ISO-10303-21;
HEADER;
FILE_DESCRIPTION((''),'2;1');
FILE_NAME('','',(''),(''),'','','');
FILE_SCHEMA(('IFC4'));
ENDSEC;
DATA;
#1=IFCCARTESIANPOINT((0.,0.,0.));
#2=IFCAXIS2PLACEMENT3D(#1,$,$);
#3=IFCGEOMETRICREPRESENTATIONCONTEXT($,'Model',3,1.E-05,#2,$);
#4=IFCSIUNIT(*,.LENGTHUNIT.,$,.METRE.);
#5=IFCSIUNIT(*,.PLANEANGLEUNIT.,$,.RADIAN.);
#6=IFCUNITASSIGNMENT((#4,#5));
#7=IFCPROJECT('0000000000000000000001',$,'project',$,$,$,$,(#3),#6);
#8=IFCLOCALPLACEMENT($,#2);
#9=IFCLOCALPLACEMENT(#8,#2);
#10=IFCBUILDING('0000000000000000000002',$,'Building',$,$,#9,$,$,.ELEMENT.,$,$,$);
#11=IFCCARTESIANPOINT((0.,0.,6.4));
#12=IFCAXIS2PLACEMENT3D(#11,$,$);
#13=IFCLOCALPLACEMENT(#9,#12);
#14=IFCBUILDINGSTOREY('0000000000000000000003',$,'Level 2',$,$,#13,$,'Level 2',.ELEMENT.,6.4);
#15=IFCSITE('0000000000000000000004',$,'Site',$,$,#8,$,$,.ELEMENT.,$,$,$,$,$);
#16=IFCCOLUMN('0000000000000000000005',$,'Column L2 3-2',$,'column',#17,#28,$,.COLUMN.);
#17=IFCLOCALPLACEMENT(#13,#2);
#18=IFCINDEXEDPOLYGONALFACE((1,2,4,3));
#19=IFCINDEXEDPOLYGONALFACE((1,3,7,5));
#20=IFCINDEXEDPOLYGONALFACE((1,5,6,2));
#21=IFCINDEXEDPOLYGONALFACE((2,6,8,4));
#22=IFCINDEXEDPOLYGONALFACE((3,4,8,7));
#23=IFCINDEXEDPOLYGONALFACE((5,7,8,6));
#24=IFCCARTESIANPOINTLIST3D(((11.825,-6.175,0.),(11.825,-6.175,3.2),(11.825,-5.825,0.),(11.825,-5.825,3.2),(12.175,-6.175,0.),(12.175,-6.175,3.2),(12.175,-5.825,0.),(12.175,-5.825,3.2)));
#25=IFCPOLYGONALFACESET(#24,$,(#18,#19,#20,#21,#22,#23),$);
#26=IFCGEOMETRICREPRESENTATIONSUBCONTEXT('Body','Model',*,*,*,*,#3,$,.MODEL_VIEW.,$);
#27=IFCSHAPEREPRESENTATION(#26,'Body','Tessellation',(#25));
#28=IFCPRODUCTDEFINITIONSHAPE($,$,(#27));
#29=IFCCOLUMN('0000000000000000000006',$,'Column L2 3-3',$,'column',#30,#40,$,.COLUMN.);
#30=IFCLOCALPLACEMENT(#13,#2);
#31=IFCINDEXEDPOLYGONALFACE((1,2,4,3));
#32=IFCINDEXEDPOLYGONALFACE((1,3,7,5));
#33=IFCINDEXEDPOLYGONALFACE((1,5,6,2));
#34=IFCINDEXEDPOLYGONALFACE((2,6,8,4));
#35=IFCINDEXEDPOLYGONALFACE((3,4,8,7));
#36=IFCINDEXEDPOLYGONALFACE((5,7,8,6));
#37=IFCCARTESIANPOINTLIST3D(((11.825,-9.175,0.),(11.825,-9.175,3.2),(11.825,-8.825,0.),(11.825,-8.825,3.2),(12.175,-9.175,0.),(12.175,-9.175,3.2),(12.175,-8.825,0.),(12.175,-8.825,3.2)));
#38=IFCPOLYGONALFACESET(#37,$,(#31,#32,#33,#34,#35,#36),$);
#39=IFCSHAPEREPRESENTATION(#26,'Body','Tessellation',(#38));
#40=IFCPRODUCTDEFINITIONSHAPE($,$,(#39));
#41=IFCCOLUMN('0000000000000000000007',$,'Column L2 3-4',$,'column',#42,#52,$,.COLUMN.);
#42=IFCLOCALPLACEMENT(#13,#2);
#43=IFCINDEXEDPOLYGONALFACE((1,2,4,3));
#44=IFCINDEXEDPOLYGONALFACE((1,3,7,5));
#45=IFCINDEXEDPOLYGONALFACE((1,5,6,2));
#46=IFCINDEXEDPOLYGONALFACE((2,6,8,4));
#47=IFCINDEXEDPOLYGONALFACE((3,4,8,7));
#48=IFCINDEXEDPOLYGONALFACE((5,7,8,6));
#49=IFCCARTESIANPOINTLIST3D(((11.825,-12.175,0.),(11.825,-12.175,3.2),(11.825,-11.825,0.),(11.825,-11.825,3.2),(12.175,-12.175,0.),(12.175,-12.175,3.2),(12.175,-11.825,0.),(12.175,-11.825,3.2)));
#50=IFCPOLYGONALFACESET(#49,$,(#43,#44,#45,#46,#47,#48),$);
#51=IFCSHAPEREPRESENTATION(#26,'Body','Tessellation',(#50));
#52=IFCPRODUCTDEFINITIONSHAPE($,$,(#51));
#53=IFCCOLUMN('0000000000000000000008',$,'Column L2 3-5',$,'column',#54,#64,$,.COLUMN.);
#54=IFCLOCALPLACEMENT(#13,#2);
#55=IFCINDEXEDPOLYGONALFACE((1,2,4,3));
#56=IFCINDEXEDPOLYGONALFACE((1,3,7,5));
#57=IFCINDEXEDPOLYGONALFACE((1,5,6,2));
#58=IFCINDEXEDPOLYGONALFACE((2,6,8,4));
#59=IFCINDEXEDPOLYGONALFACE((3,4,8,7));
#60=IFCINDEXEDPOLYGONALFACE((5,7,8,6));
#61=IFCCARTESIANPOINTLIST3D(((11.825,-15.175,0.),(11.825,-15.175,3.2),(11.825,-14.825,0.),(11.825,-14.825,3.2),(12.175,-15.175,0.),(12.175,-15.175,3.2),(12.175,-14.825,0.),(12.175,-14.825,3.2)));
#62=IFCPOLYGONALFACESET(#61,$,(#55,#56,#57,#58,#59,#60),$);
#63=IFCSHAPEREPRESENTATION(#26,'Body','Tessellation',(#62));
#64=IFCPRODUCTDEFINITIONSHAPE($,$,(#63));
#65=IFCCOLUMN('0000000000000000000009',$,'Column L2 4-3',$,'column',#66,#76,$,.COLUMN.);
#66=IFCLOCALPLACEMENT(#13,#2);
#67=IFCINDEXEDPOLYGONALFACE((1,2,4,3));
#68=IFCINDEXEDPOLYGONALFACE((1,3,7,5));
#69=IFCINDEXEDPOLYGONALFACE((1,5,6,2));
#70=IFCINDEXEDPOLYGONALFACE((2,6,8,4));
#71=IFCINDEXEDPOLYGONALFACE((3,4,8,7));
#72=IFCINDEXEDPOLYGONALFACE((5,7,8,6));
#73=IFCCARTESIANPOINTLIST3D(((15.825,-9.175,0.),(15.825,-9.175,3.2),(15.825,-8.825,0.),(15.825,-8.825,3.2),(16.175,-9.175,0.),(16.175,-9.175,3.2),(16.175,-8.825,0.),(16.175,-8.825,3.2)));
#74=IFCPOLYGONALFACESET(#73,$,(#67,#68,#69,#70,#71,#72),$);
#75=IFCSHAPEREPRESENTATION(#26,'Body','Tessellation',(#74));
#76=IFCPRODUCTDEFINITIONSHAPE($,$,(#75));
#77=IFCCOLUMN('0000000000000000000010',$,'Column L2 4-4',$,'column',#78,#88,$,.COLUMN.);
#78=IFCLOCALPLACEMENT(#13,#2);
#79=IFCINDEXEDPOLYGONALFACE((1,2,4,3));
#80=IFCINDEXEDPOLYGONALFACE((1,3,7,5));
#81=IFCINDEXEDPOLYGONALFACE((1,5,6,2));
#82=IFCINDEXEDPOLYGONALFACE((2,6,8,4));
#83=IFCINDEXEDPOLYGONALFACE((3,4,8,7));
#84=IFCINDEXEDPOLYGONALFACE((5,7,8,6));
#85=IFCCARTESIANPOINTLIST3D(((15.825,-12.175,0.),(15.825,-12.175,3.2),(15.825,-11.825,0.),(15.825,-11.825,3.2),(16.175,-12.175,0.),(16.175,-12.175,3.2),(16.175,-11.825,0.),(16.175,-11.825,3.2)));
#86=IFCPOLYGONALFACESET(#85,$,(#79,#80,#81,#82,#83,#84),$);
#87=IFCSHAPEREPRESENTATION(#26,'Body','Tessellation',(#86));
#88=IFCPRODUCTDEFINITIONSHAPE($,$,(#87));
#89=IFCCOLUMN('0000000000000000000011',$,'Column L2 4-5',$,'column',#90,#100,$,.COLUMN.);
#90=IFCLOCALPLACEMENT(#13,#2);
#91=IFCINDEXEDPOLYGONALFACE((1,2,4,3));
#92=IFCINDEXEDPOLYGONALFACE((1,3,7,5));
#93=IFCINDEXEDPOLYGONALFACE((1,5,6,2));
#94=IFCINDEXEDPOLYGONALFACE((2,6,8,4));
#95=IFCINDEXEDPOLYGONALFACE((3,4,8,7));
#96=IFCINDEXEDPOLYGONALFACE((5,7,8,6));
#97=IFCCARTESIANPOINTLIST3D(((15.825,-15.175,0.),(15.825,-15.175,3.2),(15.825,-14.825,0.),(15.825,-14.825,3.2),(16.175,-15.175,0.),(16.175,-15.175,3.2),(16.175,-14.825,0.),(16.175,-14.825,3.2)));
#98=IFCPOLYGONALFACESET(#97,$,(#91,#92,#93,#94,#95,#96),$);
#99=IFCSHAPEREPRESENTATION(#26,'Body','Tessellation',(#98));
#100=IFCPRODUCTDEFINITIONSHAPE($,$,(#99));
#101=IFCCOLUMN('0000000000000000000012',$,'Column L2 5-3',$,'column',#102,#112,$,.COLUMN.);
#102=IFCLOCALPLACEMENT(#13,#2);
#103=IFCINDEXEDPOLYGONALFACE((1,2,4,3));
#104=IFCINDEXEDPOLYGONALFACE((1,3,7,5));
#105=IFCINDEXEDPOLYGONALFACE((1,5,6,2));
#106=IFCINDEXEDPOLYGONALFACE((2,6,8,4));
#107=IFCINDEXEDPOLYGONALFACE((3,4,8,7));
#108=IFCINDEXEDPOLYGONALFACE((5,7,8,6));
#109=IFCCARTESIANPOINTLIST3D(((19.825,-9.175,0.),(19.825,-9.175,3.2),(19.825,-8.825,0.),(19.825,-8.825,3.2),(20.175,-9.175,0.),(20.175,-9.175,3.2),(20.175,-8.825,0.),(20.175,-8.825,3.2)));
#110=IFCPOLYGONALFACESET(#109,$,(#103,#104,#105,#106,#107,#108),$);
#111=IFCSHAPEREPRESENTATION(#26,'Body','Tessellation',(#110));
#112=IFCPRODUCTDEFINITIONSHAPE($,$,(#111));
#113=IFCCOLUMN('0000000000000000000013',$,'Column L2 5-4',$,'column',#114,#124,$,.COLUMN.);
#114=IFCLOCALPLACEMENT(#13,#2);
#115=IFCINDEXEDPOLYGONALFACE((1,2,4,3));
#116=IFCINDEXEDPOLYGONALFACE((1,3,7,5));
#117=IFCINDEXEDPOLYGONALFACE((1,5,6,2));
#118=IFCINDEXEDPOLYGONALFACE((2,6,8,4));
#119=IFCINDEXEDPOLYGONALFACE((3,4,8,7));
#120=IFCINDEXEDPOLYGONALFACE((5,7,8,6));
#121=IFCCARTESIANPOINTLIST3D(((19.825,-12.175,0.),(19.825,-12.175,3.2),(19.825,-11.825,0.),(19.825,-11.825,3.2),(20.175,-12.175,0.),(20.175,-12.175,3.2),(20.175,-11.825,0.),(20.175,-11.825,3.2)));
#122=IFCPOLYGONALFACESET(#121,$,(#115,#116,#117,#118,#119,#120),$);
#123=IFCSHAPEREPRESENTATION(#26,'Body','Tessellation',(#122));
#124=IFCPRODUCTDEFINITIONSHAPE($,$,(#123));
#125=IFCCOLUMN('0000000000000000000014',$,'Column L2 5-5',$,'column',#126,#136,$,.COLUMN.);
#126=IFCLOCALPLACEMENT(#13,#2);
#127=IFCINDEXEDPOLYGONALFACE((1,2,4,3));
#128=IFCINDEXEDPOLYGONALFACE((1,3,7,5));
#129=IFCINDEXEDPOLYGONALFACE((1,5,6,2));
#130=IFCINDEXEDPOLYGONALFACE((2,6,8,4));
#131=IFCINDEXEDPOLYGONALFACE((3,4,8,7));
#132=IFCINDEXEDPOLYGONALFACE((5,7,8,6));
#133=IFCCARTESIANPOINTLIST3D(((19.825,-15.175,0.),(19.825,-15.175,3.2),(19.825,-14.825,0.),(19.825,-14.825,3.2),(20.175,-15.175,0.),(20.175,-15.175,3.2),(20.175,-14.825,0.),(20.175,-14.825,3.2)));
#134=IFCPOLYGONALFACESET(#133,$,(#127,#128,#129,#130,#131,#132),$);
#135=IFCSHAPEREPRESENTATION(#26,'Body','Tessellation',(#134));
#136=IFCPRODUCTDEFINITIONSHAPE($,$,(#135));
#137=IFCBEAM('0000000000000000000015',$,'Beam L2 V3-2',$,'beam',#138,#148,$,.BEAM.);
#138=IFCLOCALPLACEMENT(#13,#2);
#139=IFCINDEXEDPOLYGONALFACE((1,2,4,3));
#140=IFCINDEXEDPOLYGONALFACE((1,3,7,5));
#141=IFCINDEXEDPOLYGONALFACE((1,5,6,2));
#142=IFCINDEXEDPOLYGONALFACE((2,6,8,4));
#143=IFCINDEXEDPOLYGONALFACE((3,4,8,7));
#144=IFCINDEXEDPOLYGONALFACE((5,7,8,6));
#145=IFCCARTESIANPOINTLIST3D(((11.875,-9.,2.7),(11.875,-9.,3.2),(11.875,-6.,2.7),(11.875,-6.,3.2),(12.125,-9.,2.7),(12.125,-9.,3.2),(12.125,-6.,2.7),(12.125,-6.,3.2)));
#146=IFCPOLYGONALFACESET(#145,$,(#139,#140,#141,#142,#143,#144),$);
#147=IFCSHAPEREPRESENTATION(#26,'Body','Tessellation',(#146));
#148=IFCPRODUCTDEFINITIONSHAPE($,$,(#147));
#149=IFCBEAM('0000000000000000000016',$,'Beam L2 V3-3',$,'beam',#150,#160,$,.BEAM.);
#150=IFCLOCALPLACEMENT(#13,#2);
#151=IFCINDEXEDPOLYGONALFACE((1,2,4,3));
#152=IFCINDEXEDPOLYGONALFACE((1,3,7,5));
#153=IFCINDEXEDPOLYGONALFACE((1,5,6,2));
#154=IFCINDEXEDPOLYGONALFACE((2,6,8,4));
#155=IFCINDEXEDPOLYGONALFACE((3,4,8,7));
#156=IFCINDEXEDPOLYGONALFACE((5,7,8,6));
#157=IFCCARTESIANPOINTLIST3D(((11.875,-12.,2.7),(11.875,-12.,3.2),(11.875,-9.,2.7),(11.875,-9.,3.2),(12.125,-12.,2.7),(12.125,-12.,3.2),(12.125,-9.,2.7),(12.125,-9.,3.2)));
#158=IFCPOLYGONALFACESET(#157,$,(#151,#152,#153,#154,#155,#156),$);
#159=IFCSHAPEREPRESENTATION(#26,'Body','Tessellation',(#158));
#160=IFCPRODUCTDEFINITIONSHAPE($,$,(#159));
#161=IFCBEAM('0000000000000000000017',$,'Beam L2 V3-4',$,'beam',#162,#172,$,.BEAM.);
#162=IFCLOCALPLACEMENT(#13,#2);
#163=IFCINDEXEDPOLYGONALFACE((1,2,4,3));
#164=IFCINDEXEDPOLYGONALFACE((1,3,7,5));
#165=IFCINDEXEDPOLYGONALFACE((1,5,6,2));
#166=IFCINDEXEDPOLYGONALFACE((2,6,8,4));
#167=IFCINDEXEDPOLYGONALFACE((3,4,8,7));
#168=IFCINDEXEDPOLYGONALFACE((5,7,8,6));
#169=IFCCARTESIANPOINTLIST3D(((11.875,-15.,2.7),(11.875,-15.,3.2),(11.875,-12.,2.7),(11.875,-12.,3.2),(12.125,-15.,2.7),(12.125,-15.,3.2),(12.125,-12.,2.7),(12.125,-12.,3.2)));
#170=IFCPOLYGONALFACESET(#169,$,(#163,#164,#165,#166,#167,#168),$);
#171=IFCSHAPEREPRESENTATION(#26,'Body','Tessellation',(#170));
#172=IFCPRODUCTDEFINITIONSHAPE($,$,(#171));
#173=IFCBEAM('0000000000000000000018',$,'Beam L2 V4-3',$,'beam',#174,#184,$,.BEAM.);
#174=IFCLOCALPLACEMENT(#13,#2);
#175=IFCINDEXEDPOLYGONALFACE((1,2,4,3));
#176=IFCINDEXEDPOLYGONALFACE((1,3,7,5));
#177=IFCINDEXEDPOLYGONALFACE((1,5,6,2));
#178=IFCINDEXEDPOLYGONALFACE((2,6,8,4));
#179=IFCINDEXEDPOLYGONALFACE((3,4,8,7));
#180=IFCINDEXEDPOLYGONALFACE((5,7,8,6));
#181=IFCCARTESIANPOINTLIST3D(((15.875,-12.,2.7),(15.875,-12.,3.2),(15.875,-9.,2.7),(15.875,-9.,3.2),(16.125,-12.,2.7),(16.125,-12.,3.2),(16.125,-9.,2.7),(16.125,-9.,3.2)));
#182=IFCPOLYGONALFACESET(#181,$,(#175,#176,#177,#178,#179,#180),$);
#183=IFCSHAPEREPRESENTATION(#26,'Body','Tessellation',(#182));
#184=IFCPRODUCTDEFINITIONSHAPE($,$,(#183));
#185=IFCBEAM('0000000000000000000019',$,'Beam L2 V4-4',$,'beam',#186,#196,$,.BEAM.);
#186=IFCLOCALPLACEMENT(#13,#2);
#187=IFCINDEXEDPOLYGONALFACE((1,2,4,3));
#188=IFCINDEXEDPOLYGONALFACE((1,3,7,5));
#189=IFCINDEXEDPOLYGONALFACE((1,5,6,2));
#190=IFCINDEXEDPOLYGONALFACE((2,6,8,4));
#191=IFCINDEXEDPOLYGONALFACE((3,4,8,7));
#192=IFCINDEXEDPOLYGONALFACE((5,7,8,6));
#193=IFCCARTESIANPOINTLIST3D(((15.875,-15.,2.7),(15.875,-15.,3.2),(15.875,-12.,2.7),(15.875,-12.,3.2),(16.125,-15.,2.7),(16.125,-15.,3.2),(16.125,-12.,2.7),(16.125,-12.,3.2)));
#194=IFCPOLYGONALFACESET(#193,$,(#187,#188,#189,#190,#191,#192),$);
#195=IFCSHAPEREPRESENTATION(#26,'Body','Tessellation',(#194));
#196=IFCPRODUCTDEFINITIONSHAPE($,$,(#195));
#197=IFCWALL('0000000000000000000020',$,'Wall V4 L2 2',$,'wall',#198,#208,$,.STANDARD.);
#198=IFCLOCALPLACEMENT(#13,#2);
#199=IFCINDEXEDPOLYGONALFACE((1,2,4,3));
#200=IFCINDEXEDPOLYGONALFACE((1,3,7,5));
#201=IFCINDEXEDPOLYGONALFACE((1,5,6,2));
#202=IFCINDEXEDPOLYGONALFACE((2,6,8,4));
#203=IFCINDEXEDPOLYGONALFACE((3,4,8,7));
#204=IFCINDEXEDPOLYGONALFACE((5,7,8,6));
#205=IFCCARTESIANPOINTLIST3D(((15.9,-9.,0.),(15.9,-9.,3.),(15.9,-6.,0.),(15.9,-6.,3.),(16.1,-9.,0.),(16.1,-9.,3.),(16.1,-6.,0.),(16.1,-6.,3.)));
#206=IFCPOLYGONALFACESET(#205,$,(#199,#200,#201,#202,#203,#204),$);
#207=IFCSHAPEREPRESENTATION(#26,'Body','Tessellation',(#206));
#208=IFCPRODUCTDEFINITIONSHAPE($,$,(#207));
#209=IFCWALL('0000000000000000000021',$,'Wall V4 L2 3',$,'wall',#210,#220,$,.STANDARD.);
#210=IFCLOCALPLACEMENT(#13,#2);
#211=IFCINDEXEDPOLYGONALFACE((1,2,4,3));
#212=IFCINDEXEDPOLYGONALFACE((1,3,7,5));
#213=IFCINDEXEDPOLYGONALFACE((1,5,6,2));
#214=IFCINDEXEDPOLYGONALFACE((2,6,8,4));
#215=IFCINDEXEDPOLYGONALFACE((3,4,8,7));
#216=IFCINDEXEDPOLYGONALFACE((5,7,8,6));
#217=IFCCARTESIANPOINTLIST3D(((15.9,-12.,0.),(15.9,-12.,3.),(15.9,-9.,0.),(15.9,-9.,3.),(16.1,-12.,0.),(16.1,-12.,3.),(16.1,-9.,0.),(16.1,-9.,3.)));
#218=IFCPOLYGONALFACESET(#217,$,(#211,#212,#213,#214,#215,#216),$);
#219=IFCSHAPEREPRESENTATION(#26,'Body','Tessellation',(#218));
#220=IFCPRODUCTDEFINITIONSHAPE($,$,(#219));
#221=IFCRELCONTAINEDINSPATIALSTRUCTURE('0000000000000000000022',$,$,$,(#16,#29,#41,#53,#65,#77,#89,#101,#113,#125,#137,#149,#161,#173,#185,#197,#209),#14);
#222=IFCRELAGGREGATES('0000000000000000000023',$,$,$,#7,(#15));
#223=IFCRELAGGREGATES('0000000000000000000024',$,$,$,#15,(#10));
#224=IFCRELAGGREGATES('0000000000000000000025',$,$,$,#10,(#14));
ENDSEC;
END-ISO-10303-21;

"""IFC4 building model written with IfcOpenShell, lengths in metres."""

from ifc_helpers import new_model, si_unit, frame, frame_2d, origin, origin_2d, place, context, subcontext, project, spatial, rectangle, extrude, element, save


model = new_model("IFC4")

# Units and contexts
model_context = context("Model", 3, precision=1e-05, world=origin())
body_context = subcontext(model_context, "Body", "Model", "MODEL_VIEW")
ifc_project = project(units=[si_unit("LENGTHUNIT", "METRE"), si_unit("PLANEANGLEUNIT", "RADIAN")], contexts=[model_context])

# Site, building, storey
site_placement = place(None, origin())
site = spatial("IfcSite", under=ifc_project, at=site_placement, Name="Site", CompositionType="ELEMENT")
building_placement = place(site_placement, origin())
building = spatial("IfcBuilding", under=site, at=building_placement, Name="Building", CompositionType="ELEMENT")
storey_placement = place(building_placement, frame((0.0, 0.0, 6.4)))
storey = spatial("IfcBuildingStorey", under=building, at=storey_placement, Name="Level 2", LongName="Level 2", CompositionType="ELEMENT", Elevation=6.4)

# Columns
for number, where, name in (
    (1, (12.0, -6.0, 0.0), "Column L2 3-2"),
    (2, (12.0, -9.0, 0.0), "Column L2 3-3"),
    (3, (12.0, -12.0, 0.0), "Column L2 3-4"),
    (4, (12.0, -15.0, 0.0), "Column L2 3-5"),
    (5, (16.0, -9.0, 0.0), "Column L2 4-3"),
    (6, (16.0, -12.0, 0.0), "Column L2 4-4"),
    (7, (16.0, -15.0, 0.0), "Column L2 4-5"),
    (8, (20.0, -9.0, 0.0), "Column L2 5-3"),
    (9, (20.0, -12.0, 0.0), "Column L2 5-4"),
    (10, (20.0, -15.0, 0.0), "Column L2 5-5"),
):
    element("IfcColumn", number, at=place(storey_placement, frame(where)), inside=storey, Name=name, ObjectType="column", PredefinedType="COLUMN", context=body_context, shape_type="SweptSolid", body=[
        extrude(rectangle(XDim=0.35, YDim=0.35, at=origin_2d()), origin(), (0.0, 0.0, 1.0), 3.2),
    ])

# Beams
for number, where, z_axis, x_axis, name in (
    (11, (12.0, -6.0, 2.95), (0.0, -1.0, 0.0), (0.0, 0.0, 1.0), "Beam L2 V3-2"),
    (12, (12.0, -9.0, 2.95), (0.0, -1.0, 0.0), (0.0, 0.0, 1.0), "Beam L2 V3-3"),
    (13, (12.0, -12.0, 2.95), (0.0, -1.0, 0.0), (0.0, 0.0, 1.0), "Beam L2 V3-4"),
    (14, (16.0, -9.0, 2.95), (0.0, -1.0, 0.0), (0.0, 0.0, 1.0), "Beam L2 V4-3"),
    (15, (16.0, -12.0, 2.95), (0.0, -1.0, 0.0), (0.0, 0.0, 1.0), "Beam L2 V4-4"),
):
    element("IfcBeam", number, at=place(storey_placement, frame(where, z_axis=z_axis, x_axis=x_axis)), inside=storey, Name=name, ObjectType="beam", PredefinedType="BEAM", context=body_context, shape_type="SweptSolid", body=[
        extrude(rectangle(XDim=0.5, YDim=0.25, at=origin_2d()), origin(), (0.0, 0.0, 1.0), 3.0),
    ])

# Walls
for number, where, z_axis, x_axis, name in (
    (16, (16.0, -6.0, 0.0), (0.0, 0.0, 1.0), (0.0, -1.0, 0.0), "Wall V4 L2 2"),
    (17, (16.0, -9.0, 0.0), (0.0, 0.0, 1.0), (0.0, -1.0, 0.0), "Wall V4 L2 3"),
):
    element("IfcWall", number, at=place(storey_placement, frame(where, z_axis=z_axis, x_axis=x_axis)), inside=storey, Name=name, ObjectType="wall", PredefinedType="STANDARD", context=body_context, shape_type="SweptSolid", body=[
        extrude(rectangle(XDim=3.0, YDim=0.2, at=frame_2d((1.5, 0.0))), origin(), (0.0, 0.0, 1.0), 3.0),
    ])

save(model, "model.ifc")
